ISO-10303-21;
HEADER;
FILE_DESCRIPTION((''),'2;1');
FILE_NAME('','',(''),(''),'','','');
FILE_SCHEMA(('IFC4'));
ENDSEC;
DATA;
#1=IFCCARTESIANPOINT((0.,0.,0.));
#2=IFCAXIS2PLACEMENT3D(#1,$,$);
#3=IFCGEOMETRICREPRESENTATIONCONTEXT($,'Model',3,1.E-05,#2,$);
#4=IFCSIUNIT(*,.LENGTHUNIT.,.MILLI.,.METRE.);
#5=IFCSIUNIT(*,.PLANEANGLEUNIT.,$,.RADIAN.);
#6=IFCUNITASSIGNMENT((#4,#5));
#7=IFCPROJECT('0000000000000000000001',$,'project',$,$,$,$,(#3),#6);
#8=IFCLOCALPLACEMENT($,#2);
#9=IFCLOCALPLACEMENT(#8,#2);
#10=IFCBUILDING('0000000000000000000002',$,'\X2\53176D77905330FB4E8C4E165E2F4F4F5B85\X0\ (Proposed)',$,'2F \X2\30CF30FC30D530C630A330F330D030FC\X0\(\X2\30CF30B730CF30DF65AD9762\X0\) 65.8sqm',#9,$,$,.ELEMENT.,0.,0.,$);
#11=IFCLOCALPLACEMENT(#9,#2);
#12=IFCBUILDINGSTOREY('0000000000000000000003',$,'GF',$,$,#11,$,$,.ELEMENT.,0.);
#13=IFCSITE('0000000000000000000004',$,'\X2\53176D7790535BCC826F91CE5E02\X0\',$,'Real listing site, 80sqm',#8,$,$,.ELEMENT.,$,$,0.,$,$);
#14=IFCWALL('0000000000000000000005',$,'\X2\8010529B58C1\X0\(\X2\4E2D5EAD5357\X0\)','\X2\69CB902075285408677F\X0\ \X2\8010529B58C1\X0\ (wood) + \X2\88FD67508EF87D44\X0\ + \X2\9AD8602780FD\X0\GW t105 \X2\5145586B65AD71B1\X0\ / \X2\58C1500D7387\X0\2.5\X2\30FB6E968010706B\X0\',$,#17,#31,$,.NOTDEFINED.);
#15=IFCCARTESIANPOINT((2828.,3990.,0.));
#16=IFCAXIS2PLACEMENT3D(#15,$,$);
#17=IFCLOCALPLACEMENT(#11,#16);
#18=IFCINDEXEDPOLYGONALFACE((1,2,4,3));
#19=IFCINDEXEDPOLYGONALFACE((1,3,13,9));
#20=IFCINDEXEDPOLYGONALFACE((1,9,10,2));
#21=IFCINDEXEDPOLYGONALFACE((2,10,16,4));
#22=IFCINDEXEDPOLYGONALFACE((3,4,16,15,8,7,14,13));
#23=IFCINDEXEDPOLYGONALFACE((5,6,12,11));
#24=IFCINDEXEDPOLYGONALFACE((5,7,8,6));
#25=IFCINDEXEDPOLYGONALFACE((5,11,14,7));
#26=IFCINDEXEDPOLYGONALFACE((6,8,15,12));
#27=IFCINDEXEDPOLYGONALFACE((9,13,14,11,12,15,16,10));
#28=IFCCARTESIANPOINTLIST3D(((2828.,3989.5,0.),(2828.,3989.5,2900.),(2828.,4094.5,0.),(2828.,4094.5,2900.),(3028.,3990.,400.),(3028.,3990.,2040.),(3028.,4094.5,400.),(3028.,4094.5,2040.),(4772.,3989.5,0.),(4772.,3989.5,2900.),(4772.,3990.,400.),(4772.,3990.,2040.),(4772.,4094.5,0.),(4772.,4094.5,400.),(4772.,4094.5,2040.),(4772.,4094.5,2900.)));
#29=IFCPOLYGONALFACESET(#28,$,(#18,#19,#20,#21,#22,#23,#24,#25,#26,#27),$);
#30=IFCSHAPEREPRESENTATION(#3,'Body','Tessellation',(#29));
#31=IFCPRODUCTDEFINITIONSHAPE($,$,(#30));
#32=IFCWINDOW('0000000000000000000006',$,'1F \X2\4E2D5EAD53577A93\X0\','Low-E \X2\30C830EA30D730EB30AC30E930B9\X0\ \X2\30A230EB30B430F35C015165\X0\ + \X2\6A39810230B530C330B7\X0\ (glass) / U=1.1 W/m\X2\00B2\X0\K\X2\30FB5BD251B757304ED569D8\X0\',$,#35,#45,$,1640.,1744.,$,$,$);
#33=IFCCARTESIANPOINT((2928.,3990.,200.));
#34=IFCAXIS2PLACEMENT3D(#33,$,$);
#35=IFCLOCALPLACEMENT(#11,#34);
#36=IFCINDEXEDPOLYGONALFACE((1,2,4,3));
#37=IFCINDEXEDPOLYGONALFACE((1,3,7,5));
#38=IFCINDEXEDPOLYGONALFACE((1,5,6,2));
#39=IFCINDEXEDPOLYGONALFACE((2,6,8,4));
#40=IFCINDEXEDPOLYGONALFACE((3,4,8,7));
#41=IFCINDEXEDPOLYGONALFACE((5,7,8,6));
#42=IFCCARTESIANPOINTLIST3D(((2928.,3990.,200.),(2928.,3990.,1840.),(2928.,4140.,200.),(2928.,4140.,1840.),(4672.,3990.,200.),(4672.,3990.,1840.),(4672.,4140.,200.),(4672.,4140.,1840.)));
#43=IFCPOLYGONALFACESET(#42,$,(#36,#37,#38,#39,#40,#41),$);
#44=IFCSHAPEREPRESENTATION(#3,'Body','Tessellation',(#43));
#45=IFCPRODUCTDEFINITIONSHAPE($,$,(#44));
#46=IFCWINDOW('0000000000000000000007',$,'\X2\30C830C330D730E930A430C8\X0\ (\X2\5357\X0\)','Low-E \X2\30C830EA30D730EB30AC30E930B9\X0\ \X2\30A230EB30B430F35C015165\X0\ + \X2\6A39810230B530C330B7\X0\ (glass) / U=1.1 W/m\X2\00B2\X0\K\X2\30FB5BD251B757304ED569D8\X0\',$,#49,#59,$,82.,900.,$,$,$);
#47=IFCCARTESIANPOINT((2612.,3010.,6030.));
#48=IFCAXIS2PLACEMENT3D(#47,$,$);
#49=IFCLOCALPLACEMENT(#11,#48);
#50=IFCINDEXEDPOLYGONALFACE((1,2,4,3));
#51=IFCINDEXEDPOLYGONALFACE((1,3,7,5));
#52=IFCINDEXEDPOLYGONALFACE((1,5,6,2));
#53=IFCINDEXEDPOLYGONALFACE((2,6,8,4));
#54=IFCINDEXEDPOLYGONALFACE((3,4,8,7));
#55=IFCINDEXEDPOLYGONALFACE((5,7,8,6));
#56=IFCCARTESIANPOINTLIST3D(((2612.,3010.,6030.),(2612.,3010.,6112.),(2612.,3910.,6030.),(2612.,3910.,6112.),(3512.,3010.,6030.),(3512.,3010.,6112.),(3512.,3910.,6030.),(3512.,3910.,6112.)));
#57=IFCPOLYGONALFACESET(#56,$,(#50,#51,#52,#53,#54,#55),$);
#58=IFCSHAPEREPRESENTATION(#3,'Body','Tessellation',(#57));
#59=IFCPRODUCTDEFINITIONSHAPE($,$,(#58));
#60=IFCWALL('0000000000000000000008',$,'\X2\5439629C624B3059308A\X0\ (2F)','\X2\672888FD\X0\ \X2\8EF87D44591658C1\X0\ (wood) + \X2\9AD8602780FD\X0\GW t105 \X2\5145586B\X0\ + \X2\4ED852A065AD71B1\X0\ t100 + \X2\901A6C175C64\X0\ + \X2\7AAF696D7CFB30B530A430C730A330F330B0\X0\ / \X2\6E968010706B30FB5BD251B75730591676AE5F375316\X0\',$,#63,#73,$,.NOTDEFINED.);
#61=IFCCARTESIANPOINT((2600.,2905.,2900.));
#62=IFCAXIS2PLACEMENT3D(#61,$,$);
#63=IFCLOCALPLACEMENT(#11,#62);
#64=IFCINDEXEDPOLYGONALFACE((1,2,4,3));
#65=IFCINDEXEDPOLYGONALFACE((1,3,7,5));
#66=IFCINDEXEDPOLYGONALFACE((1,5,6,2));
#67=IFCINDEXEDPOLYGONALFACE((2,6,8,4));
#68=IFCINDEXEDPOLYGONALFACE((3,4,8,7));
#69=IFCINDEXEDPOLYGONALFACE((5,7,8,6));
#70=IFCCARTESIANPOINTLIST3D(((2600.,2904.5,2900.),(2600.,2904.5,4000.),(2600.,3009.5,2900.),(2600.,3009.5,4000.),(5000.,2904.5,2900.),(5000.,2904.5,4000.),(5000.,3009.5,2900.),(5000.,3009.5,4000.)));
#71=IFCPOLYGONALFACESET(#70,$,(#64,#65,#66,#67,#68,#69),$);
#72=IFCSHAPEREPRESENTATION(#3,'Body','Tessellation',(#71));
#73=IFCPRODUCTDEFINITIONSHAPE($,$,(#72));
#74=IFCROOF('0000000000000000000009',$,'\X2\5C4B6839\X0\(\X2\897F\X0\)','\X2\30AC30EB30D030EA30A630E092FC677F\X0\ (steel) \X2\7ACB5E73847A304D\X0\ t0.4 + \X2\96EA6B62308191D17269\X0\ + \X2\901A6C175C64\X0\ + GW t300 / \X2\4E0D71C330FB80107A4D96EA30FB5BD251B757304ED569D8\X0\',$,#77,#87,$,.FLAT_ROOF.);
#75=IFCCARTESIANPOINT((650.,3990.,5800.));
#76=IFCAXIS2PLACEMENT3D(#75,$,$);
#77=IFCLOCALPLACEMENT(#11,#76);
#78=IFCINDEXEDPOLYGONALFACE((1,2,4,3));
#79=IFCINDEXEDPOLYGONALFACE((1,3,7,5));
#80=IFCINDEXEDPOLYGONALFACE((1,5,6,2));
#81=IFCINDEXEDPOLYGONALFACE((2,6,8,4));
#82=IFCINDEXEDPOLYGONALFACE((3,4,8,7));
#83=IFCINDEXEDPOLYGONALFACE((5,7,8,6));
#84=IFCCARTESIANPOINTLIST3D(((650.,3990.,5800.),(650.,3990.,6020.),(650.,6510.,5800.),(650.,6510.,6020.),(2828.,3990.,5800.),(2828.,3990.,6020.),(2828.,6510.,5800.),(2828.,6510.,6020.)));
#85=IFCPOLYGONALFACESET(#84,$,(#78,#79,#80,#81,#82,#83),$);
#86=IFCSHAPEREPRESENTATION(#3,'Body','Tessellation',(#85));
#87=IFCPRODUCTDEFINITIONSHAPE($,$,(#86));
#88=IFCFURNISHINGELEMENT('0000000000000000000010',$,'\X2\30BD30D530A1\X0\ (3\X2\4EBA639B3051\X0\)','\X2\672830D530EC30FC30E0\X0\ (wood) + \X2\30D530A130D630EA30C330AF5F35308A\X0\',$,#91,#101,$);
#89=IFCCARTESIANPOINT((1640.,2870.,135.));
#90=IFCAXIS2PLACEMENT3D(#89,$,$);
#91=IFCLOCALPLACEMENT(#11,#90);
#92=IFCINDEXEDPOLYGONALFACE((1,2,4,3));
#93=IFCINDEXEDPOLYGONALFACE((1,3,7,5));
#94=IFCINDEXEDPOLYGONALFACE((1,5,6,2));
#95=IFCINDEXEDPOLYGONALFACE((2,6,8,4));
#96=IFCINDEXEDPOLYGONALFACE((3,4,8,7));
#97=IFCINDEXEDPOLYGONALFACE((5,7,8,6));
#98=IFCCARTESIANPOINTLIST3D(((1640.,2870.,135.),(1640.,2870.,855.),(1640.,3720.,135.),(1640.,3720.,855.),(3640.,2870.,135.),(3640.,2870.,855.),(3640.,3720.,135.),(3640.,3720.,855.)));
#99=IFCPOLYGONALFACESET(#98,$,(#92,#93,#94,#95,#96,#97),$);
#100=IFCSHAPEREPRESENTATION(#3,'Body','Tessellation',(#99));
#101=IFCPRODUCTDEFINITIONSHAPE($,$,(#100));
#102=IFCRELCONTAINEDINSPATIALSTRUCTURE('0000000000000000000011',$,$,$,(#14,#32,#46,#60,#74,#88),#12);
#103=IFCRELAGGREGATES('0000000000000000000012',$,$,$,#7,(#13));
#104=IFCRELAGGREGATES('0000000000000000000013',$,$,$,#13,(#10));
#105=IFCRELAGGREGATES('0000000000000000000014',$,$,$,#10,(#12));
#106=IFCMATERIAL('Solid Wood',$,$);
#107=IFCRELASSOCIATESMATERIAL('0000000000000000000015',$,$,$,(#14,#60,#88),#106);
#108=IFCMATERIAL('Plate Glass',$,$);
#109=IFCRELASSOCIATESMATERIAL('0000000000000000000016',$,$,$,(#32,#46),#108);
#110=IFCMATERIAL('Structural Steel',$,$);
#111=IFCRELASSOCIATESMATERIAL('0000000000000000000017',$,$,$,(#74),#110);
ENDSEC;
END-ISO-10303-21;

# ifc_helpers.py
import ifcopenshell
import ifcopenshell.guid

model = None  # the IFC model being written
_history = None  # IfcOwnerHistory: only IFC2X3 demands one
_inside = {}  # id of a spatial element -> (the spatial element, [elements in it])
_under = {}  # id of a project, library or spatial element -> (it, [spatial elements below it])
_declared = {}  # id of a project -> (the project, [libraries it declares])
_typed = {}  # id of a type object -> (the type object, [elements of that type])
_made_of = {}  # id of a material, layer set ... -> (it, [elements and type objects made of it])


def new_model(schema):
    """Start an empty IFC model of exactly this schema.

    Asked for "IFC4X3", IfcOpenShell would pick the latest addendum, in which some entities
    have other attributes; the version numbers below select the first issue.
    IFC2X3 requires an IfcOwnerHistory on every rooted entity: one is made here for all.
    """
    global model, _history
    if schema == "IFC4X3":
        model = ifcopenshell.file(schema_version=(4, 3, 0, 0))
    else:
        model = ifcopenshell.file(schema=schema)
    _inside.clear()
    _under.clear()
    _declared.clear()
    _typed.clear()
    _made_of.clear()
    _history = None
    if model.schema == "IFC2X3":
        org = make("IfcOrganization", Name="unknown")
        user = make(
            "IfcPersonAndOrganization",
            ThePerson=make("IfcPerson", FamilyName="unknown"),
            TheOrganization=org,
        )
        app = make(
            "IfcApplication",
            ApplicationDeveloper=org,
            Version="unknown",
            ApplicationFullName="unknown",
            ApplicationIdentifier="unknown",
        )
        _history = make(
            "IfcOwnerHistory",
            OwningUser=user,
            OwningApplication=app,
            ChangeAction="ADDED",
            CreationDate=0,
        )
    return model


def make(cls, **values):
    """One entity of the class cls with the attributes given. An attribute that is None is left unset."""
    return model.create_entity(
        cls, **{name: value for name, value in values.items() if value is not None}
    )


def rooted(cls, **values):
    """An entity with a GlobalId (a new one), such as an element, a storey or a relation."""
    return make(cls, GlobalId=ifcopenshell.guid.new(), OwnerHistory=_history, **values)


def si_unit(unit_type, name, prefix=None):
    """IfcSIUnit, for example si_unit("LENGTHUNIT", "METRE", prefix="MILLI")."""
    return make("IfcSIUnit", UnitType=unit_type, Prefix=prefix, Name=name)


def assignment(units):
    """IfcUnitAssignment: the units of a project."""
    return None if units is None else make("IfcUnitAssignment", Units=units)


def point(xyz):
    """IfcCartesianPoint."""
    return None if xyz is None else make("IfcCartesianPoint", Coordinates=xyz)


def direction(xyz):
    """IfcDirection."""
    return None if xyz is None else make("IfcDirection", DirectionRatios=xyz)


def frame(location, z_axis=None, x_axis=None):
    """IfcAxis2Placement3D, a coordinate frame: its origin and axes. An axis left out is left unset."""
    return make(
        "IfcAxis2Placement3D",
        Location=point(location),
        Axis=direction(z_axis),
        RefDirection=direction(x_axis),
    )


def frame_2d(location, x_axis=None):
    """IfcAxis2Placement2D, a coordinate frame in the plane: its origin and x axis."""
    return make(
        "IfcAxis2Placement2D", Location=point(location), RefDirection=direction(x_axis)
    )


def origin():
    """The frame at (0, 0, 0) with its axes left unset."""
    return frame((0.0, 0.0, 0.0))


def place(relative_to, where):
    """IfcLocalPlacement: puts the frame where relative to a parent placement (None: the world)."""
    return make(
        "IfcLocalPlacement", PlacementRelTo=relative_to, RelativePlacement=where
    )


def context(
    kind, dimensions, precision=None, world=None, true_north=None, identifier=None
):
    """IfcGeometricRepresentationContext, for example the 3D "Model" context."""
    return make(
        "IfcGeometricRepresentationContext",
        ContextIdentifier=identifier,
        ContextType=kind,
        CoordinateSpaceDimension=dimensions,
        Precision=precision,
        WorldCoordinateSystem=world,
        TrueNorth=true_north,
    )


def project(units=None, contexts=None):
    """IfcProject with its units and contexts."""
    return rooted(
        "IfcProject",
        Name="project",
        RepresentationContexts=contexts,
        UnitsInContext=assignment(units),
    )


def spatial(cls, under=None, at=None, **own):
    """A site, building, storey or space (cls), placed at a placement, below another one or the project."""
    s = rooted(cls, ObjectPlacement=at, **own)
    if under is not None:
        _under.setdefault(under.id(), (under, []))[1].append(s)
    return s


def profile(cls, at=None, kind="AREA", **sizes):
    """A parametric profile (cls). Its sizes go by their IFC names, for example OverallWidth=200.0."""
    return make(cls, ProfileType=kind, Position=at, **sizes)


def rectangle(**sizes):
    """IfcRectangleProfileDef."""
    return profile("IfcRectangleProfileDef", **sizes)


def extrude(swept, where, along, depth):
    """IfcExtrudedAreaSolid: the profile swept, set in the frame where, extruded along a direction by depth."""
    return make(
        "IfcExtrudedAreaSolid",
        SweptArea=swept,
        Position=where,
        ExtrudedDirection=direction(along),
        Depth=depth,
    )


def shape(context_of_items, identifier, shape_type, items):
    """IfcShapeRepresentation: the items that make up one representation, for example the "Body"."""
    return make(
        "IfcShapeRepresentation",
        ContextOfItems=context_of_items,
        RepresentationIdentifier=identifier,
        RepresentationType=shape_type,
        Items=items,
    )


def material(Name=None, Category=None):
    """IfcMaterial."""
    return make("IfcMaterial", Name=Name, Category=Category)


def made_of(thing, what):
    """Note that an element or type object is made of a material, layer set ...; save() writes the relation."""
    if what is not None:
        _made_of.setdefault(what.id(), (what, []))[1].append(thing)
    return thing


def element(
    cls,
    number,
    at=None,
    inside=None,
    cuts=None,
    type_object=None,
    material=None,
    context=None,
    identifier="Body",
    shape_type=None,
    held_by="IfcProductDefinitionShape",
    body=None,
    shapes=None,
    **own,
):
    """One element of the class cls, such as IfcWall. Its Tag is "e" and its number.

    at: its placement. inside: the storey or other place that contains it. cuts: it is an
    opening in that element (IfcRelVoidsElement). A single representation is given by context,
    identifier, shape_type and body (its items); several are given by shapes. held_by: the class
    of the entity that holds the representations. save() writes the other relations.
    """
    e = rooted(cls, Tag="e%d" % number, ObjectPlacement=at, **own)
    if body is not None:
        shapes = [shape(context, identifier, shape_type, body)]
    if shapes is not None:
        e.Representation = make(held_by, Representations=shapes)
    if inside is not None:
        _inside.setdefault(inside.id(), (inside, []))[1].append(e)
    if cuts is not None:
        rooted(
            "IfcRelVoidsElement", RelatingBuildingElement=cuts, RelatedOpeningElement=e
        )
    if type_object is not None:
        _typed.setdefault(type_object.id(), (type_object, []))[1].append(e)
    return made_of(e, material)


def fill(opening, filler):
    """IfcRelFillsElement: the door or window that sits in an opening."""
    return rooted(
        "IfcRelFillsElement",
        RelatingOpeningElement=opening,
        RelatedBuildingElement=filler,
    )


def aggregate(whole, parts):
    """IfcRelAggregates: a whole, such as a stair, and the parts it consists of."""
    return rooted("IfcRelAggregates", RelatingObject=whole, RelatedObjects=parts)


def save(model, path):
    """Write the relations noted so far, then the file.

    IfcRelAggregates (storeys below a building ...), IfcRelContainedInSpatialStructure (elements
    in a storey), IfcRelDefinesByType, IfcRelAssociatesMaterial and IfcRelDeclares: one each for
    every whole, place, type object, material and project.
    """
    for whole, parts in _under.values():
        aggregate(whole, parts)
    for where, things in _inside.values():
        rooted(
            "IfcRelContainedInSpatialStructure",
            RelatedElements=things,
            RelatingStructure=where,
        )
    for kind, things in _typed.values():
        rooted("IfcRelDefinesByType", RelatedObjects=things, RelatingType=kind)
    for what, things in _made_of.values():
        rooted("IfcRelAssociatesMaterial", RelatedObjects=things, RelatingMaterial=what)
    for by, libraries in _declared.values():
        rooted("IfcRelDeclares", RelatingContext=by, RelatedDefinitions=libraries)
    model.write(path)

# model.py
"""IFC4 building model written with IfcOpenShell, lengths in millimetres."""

from ifc_helpers import new_model, si_unit, frame, frame_2d, origin, place, context, project, spatial, rectangle, extrude, material, element, fill, save


model = new_model("IFC4")

# Units and contexts
model_context = context("Model", 3, precision=1e-05, world=origin())
ifc_project = project(units=[si_unit("LENGTHUNIT", "METRE", prefix="MILLI"), si_unit("PLANEANGLEUNIT", "RADIAN")], contexts=[model_context])

# Site, building, storey
site_placement = place(None, origin())
site = spatial("IfcSite", under=ifc_project, at=site_placement, Name="北海道富良野市", ObjectType="Real listing site, 80sqm", CompositionType="ELEMENT", RefElevation=0.0)
building_placement = place(site_placement, origin())
building = spatial("IfcBuilding", under=site, at=building_placement, Name="北海道・二世帯住宅 (Proposed)", ObjectType="2F ハーフティンバー(ハシハミ断面) 65.8sqm", CompositionType="ELEMENT", ElevationOfRefHeight=0.0, ElevationOfTerrain=0.0)
storey_placement = place(building_placement, origin())
storey = spatial("IfcBuildingStorey", under=building, at=storey_placement, Name="GF", CompositionType="ELEMENT", Elevation=0.0)

# Shared definitions
ifc_material_1 = material(Name="Solid Wood")

# Wall, opening, window
wall_1_placement = place(storey_placement, frame((2828.0, 3990.0, 0.0)))
wall_1 = element("IfcWall", 1, at=wall_1_placement, inside=storey, material=ifc_material_1, Name="耐力壁(中庭南)", Description="構造用合板 耐力壁 (wood) + 製材軸組 + 高性能GW t105 充填断熱 / 壁倍率2.5・準耐火", PredefinedType="NOTDEFINED", context=model_context, shape_type="SweptSolid", body=[
    extrude(rectangle(XDim=1944.0, YDim=105.0, at=frame_2d((972.0, 52.0))), frame((2828.0, 3990.0, 0.0)), (0.0, 0.0, 1.0), 2900.0),
])
opening_placement = place(storey_placement, frame((2928.0, 3990.0, 200.0)))
opening = element("IfcOpeningElement", 2, at=opening_placement, cuts=wall_1, PredefinedType="NOTDEFINED", context=model_context, shape_type="SweptSolid", body=[
    extrude(rectangle(XDim=1744.0, YDim=150.0, at=frame_2d((872.0, 75.0))), frame((2928.0, 3990.0, 200.0)), (0.0, 0.0, 1.0), 1640.0),
])
ifc_material_2 = material(Name="Plate Glass")
window_1_placement = place(storey_placement, frame((2928.0, 3990.0, 200.0)))
window_1 = element("IfcWindow", 3, at=window_1_placement, inside=storey, material=ifc_material_2, Name="1F 中庭南窓", Description="Low-E トリプルガラス アルゴン封入 + 樹脂サッシ (glass) / U=1.1 W/m²K・寒冷地仕様", OverallHeight=1640.0, OverallWidth=1744.0, context=model_context, shape_type="SweptSolid", body=[
    extrude(rectangle(XDim=1744.0, YDim=150.0, at=frame_2d((872.0, 75.0))), frame((2928.0, 3990.0, 200.0)), (0.0, 0.0, 1.0), 1640.0),
])
fill(opening, window_1)

# Window
window_2_placement = place(storey_placement, frame((2612.0, 3010.0, 6030.0)))
element("IfcWindow", 4, at=window_2_placement, inside=storey, material=ifc_material_2, Name="トップライト (南)", Description="Low-E トリプルガラス アルゴン封入 + 樹脂サッシ (glass) / U=1.1 W/m²K・寒冷地仕様", OverallHeight=82.0, OverallWidth=900.0, context=model_context, shape_type="SweptSolid", body=[
    extrude(rectangle(XDim=900.0, YDim=900.0, at=frame_2d((450.0, 450.0))), frame((2612.0, 3010.0, 6030.0)), (0.0, 0.0, 1.0), 82.0),
])

# Wall
wall_2_placement = place(storey_placement, frame((2600.0, 2905.0, 2900.0)))
element("IfcWall", 5, at=wall_2_placement, inside=storey, material=ifc_material_1, Name="吹抜手すり (2F)", Description="木製 軸組外壁 (wood) + 高性能GW t105 充填 + 付加断熱 t100 + 通気層 + 窯業系サイディング / 準耐火・寒冷地外皮強化", PredefinedType="NOTDEFINED", context=model_context, shape_type="SweptSolid", body=[
    extrude(rectangle(XDim=2400.0, YDim=105.0, at=frame_2d((1200.0, 52.0))), frame((2600.0, 2905.0, 2900.0)), (0.0, 0.0, 1.0), 1100.0),
])

# Roof
ifc_material_3 = material(Name="Structural Steel")
for number, where, name in (
    (6, (650.0, 3990.0, 5800.0), "屋根(西)"),
):
    element("IfcRoof", number, at=place(storey_placement, frame(where)), inside=storey, material=ifc_material_3, Name=name, Description="ガルバリウム鋼板 (steel) 立平葺き t0.4 + 雪止め金物 + 通気層 + GW t300 / 不燃・耐積雪・寒冷地仕様", PredefinedType="FLAT_ROOF", context=model_context, shape_type="SweptSolid", body=[
        extrude(rectangle(XDim=2178.0, YDim=2520.0, at=frame_2d((1089.0, 1260.0))), frame((650.0, 3990.0, 5800.0)), (0.0, 0.0, 1.0), 220.0),
    ])

# Furnishing element
furnishing_placement = place(storey_placement, frame((1640.0, 2870.0, 135.0)))
element("IfcFurnishingElement", 7, at=furnishing_placement, inside=storey, material=ifc_material_1, Name="ソファ (3人掛け)", Description="木フレーム (wood) + ファブリック張り", context=model_context, shape_type="SweptSolid", body=[
    extrude(rectangle(XDim=2000.0, YDim=850.0, at=frame_2d((1000.0, 425.0))), frame((1640.0, 2870.0, 135.0)), (0.0, 0.0, 1.0), 720.0),
])

save(model, "model.ifc")
